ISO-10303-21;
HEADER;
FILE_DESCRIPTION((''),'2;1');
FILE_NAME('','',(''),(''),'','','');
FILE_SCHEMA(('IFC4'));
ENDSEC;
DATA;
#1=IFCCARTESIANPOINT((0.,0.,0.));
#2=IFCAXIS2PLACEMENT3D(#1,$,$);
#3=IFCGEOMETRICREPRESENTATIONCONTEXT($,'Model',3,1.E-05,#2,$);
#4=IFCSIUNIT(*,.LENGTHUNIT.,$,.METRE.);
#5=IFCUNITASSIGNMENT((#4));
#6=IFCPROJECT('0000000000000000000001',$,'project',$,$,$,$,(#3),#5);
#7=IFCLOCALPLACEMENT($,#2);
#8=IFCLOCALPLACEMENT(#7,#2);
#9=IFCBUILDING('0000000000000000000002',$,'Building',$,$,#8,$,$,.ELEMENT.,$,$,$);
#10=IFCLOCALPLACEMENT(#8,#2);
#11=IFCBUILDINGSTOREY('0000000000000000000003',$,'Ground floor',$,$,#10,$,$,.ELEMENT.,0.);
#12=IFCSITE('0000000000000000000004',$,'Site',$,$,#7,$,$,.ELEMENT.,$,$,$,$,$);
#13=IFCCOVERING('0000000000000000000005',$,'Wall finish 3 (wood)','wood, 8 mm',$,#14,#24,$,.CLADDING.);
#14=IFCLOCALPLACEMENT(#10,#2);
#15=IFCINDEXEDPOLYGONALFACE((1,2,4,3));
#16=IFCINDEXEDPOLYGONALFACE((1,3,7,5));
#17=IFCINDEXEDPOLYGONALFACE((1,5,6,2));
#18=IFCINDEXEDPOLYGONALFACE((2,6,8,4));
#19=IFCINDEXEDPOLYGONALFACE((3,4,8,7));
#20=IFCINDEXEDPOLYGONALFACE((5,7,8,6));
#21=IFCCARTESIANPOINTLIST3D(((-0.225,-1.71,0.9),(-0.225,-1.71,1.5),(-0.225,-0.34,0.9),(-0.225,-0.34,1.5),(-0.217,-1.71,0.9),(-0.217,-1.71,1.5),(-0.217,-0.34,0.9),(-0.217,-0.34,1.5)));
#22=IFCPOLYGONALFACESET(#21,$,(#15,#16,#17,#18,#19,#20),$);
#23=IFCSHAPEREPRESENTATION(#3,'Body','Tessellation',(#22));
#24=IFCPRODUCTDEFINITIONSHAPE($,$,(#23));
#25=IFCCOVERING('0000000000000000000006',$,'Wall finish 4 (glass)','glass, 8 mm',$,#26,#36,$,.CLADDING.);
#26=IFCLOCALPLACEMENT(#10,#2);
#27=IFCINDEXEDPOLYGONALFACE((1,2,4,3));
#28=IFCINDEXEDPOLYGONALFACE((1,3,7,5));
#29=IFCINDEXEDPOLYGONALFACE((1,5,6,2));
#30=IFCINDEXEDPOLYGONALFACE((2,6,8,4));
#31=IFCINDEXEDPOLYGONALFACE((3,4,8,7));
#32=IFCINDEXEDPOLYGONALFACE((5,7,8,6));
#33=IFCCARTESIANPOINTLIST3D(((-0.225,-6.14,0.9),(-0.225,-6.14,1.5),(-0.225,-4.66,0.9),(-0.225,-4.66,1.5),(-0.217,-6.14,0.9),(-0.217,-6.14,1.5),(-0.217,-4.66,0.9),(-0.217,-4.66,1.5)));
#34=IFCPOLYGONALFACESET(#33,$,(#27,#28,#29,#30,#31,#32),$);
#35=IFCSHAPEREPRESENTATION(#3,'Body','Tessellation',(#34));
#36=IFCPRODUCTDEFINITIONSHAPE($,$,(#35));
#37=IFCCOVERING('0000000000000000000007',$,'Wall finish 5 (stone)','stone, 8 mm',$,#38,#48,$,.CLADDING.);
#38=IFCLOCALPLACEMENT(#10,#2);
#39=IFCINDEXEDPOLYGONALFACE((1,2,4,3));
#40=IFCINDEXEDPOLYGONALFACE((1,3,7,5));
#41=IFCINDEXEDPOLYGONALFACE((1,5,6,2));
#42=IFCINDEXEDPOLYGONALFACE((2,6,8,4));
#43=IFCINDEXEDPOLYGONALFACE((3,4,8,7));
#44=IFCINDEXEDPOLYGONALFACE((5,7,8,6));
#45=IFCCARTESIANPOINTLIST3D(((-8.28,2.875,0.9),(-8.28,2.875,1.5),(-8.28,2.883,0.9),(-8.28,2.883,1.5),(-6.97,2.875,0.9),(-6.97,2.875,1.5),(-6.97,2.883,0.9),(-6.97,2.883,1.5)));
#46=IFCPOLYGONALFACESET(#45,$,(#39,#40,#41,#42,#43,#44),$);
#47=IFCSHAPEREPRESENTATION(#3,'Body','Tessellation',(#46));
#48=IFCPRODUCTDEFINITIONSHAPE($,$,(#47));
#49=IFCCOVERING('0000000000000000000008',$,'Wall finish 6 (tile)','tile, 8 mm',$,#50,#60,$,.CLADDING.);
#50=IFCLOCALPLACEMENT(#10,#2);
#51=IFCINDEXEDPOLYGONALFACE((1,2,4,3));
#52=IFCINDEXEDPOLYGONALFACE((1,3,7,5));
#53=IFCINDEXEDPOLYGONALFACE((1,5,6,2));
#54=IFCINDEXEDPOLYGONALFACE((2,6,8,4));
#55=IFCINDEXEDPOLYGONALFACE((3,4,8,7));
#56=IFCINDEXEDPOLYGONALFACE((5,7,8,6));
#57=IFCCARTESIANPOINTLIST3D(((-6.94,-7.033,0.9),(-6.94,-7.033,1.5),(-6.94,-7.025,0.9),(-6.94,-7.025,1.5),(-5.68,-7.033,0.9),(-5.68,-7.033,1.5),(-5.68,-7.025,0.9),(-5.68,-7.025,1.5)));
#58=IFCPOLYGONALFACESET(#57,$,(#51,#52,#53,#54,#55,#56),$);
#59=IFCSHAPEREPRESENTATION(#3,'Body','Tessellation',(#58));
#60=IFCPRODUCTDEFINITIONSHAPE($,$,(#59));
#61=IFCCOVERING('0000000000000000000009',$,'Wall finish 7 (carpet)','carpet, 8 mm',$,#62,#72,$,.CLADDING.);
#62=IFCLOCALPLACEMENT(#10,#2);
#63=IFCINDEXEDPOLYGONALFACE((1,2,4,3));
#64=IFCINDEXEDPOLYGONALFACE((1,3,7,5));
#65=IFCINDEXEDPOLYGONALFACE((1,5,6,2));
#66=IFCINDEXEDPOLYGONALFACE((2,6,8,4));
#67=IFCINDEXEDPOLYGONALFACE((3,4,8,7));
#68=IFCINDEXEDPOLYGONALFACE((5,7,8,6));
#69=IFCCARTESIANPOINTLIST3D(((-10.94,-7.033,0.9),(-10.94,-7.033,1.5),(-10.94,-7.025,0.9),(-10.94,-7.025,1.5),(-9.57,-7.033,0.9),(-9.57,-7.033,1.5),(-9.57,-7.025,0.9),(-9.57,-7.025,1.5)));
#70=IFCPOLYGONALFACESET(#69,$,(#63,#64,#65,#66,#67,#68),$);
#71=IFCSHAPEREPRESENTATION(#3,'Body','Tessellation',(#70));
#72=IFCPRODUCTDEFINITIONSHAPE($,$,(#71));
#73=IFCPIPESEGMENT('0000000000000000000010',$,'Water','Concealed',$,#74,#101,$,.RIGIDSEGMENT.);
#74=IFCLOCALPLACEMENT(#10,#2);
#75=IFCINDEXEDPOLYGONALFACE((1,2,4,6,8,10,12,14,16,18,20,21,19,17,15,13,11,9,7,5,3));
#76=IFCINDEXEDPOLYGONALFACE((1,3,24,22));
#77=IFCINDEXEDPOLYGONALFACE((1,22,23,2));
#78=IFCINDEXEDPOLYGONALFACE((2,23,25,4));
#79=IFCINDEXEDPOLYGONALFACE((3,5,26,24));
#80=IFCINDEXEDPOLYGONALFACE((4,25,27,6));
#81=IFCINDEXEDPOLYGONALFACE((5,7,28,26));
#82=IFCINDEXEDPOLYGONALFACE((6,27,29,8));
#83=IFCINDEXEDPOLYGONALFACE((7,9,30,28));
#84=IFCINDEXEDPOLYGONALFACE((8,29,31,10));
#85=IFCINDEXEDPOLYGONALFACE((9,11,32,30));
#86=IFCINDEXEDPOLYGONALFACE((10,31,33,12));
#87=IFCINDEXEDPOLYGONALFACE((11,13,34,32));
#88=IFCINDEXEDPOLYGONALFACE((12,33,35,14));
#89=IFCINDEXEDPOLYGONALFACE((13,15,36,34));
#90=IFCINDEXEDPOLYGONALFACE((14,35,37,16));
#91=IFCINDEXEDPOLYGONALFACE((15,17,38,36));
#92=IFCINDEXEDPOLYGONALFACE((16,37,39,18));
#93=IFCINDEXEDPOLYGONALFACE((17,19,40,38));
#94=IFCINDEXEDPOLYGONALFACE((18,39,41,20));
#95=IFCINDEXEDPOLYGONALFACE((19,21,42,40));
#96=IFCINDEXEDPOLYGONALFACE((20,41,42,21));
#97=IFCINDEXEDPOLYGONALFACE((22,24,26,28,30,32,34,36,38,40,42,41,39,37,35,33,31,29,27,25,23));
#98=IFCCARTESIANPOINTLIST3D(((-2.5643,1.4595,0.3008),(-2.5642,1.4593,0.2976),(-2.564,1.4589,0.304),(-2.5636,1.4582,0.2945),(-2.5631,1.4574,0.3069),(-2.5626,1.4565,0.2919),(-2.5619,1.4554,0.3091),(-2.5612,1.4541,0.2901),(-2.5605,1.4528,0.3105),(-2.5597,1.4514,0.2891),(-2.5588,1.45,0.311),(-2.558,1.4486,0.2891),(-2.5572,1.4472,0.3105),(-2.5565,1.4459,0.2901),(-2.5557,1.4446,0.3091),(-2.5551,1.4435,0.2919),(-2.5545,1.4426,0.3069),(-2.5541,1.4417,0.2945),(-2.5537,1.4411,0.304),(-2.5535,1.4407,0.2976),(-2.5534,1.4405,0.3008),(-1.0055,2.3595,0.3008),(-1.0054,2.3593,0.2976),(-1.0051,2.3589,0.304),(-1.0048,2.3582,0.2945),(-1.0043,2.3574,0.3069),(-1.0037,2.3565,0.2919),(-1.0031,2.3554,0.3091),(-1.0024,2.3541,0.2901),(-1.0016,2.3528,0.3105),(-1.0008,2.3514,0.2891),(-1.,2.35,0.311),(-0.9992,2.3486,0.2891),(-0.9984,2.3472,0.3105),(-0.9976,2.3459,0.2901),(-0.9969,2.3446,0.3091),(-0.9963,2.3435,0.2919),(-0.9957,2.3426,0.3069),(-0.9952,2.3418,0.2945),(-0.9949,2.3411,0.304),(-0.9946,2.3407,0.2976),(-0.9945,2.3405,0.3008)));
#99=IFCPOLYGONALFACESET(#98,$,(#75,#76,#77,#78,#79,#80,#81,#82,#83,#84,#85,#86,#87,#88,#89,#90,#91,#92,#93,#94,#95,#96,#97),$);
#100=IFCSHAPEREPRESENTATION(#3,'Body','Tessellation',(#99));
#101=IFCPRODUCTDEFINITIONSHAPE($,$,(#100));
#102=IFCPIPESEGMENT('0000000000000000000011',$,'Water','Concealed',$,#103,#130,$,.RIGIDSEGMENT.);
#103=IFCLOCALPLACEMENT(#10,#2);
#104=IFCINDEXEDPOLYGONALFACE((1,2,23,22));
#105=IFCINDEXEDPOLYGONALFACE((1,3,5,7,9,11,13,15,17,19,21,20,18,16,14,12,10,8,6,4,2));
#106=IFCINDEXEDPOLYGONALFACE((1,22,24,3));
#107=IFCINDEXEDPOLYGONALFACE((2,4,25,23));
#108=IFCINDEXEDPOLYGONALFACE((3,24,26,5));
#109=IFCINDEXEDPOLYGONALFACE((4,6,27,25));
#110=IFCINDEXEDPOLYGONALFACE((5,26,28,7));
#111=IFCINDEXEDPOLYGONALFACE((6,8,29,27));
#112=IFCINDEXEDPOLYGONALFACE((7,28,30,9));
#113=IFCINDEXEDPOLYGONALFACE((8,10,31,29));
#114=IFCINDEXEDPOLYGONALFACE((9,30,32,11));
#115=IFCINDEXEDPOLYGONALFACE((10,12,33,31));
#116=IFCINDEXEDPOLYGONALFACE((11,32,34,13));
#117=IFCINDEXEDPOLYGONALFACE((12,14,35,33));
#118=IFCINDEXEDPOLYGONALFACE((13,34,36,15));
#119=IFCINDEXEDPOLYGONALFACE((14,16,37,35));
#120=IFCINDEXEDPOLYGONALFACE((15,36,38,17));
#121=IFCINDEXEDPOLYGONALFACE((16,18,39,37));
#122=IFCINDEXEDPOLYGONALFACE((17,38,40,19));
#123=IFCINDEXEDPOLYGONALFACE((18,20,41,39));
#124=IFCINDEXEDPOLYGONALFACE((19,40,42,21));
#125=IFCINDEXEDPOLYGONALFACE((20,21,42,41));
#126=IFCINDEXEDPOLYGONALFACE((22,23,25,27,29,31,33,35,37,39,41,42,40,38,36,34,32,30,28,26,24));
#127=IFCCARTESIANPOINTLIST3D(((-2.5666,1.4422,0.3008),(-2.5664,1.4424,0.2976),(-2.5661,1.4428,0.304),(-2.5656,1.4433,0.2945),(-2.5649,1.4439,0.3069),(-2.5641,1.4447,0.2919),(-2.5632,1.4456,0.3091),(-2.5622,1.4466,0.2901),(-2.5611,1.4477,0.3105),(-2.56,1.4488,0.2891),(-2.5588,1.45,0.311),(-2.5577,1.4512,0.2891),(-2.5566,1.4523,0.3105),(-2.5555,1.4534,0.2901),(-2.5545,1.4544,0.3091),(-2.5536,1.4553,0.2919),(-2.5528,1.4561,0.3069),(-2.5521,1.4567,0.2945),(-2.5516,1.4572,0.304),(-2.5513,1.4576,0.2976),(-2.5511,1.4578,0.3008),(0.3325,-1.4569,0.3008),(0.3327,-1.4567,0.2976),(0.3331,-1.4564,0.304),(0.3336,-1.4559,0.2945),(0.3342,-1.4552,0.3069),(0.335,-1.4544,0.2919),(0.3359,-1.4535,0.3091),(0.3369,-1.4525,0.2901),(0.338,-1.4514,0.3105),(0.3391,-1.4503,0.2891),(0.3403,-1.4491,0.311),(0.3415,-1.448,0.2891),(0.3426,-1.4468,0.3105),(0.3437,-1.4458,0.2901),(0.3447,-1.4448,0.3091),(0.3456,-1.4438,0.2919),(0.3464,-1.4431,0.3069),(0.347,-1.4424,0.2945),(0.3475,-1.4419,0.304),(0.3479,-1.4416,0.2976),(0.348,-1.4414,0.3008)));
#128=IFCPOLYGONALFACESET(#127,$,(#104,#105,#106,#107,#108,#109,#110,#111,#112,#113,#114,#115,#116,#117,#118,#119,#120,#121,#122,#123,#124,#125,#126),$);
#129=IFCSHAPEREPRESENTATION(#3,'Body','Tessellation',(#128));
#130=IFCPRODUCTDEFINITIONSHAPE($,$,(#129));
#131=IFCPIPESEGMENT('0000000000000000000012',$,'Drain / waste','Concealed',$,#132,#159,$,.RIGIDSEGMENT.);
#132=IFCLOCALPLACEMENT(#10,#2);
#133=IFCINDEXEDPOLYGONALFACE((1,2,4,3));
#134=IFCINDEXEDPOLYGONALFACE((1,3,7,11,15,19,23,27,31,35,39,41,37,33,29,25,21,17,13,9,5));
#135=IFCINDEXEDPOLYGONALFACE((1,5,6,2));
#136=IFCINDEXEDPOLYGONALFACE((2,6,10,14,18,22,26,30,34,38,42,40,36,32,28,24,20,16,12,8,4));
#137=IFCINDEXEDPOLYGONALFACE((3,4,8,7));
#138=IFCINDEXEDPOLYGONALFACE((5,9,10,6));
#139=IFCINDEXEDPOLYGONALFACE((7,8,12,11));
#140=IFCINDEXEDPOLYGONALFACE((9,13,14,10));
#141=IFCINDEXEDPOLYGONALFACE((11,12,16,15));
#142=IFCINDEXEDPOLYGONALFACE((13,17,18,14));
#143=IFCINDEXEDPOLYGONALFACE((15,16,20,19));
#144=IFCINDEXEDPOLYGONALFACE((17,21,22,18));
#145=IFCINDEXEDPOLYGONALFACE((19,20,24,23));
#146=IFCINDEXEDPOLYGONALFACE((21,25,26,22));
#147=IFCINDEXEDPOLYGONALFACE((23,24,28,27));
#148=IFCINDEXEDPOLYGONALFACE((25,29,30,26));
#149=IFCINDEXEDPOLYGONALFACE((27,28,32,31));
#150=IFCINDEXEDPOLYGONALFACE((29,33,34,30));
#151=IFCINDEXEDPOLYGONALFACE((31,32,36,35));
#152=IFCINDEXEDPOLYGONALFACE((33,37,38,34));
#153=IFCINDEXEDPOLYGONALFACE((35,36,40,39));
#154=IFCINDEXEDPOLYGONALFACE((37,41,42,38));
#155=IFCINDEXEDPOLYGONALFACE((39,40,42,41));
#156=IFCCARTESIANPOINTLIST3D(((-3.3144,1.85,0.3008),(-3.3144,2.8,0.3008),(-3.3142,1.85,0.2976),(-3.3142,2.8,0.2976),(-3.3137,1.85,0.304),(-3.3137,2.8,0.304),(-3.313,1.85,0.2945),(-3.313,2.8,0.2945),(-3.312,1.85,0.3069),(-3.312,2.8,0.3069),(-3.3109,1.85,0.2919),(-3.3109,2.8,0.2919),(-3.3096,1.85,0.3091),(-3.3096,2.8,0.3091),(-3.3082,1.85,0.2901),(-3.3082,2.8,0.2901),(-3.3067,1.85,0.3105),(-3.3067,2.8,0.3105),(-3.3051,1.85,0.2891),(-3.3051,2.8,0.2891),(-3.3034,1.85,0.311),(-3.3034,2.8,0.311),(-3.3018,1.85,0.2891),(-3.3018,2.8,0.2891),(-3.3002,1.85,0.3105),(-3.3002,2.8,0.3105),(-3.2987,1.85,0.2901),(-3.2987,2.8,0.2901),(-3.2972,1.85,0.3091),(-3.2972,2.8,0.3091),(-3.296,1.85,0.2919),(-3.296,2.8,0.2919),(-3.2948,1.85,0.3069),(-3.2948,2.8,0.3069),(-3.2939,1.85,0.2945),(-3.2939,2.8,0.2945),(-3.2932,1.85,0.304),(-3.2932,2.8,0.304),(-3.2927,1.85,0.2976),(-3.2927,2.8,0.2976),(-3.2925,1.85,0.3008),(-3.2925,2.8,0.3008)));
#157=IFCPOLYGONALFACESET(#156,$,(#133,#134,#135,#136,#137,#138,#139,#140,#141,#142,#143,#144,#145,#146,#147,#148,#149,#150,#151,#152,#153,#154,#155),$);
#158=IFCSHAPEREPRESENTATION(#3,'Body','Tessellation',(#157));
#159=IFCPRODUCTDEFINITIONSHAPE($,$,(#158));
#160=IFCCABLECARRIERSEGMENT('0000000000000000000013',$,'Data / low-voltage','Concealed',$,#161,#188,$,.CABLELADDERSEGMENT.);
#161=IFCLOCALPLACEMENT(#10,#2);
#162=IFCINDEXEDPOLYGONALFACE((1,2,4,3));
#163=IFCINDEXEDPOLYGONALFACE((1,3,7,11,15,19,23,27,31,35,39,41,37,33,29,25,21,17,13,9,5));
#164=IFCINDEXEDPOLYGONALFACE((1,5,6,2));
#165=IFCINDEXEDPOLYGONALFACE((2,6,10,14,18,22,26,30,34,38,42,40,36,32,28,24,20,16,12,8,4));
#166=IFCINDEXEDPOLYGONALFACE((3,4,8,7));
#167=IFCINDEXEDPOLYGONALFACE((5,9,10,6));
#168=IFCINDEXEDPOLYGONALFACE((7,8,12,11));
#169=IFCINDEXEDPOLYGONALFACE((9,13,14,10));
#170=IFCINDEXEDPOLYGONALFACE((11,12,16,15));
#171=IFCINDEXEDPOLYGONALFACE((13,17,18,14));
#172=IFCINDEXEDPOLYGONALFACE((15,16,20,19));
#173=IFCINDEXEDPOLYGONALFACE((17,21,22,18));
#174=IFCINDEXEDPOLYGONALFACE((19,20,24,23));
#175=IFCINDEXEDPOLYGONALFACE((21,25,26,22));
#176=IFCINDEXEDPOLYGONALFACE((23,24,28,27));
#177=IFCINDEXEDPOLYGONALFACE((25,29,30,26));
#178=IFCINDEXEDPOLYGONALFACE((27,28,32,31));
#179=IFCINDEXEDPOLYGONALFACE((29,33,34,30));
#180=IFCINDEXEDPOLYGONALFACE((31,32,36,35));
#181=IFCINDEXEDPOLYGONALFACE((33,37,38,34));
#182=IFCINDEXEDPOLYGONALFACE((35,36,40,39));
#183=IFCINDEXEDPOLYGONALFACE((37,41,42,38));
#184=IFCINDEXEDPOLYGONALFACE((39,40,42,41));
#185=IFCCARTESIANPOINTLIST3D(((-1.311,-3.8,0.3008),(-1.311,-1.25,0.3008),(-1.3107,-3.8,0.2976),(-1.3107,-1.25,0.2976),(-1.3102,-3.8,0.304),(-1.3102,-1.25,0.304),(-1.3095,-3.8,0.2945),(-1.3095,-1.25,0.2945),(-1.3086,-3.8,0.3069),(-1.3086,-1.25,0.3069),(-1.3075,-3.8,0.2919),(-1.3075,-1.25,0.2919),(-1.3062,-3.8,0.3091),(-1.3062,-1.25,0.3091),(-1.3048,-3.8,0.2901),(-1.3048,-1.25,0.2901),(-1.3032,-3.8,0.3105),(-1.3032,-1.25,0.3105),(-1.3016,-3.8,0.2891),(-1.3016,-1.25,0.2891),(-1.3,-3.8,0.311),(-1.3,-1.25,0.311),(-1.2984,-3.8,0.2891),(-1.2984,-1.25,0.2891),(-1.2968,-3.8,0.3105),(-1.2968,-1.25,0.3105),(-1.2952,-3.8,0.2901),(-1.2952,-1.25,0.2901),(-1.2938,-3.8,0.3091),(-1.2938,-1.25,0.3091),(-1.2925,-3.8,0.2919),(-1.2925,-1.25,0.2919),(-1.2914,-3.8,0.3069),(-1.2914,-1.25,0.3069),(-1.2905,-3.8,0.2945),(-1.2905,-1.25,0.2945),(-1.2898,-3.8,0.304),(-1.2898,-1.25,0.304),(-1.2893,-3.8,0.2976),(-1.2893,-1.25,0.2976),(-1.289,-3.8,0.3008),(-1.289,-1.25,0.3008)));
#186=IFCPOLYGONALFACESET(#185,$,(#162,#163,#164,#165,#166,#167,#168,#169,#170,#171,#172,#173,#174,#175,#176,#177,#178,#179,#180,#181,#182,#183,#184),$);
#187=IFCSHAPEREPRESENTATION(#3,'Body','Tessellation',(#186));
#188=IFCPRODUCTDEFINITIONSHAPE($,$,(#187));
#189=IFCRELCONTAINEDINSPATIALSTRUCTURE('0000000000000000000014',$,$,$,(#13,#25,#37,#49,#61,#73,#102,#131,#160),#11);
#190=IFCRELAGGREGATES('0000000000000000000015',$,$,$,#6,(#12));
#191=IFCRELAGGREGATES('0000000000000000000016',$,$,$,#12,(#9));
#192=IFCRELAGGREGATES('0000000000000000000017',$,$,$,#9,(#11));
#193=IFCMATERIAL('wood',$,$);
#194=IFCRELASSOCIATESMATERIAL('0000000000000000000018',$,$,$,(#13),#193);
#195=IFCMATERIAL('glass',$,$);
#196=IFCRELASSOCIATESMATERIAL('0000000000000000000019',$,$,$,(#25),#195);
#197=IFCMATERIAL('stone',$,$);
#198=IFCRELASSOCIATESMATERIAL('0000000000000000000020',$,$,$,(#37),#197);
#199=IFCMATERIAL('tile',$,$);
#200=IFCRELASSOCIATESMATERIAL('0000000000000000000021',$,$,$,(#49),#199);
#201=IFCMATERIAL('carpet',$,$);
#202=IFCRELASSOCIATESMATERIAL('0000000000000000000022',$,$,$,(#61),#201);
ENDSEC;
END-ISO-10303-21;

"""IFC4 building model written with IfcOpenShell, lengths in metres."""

from ifc_helpers import new_model, si_unit, frame, origin, origin_with_axes, origin_2d, place, context, project, spatial, polyline, circle, outline, extrude, material, element, save


model = new_model("IFC4")

# Units and contexts
model_context = context("Model", 3, precision=1e-05, world=origin())
ifc_project = project(units=[si_unit("LENGTHUNIT", "METRE")], contexts=[model_context])

# Site, building, storey
site_placement = place(None, origin())
site = spatial("IfcSite", under=ifc_project, at=site_placement, Name="Site", CompositionType="ELEMENT")
building_placement = place(site_placement, origin())
building = spatial("IfcBuilding", under=site, at=building_placement, Name="Building", CompositionType="ELEMENT")
storey_placement = place(building_placement, origin())
storey = spatial("IfcBuildingStorey", under=building, at=storey_placement, Name="Ground floor", CompositionType="ELEMENT", Elevation=0.0)

# Coverings
ifc_material_1 = material(Name="tile")
ifc_material_2 = material(Name="wood")
covering_1_placement = place(storey_placement, origin_with_axes())
element("IfcCovering", 1, at=covering_1_placement, inside=storey, material=ifc_material_2, Name="Wall finish 3 (wood)", Description="wood, 8 mm", PredefinedType="CLADDING", context=model_context, shape_type="SweptSolid", body=[
    extrude(outline(polyline([(-0.225, -0.34), (-0.225, -1.71), (-0.217, -1.71), (-0.217, -0.34), (-0.225, -0.34)])), frame((0.0, 0.0, 0.9)), (0.0, 0.0, 1.0), 0.6),
])
ifc_material_3 = material(Name="glass")
covering_2_placement = place(storey_placement, origin_with_axes())
element("IfcCovering", 2, at=covering_2_placement, inside=storey, material=ifc_material_3, Name="Wall finish 4 (glass)", Description="glass, 8 mm", PredefinedType="CLADDING", context=model_context, shape_type="SweptSolid", body=[
    extrude(outline(polyline([(-0.225, -4.66), (-0.225, -6.14), (-0.217, -6.14), (-0.217, -4.66), (-0.225, -4.66)])), frame((0.0, 0.0, 0.9)), (0.0, 0.0, 1.0), 0.6),
])
ifc_material_4 = material(Name="stone")
covering_3_placement = place(storey_placement, origin_with_axes())
element("IfcCovering", 3, at=covering_3_placement, inside=storey, material=ifc_material_4, Name="Wall finish 5 (stone)", Description="stone, 8 mm", PredefinedType="CLADDING", context=model_context, shape_type="SweptSolid", body=[
    extrude(outline(polyline([(-8.28, 2.875), (-6.97, 2.875), (-6.97, 2.883), (-8.28, 2.883), (-8.28, 2.875)])), frame((0.0, 0.0, 0.9)), (0.0, 0.0, 1.0), 0.6),
])
covering_4_placement = place(storey_placement, origin_with_axes())
element("IfcCovering", 4, at=covering_4_placement, inside=storey, material=ifc_material_1, Name="Wall finish 6 (tile)", Description="tile, 8 mm", PredefinedType="CLADDING", context=model_context, shape_type="SweptSolid", body=[
    extrude(outline(polyline([(-5.68, -7.025), (-6.94, -7.025), (-6.94, -7.033), (-5.68, -7.033), (-5.68, -7.025)])), frame((0.0, 0.0, 0.9)), (0.0, 0.0, 1.0), 0.6),
])
ifc_material_5 = material(Name="carpet")
covering_5_placement = place(storey_placement, origin_with_axes())
element("IfcCovering", 5, at=covering_5_placement, inside=storey, material=ifc_material_5, Name="Wall finish 7 (carpet)", Description="carpet, 8 mm", PredefinedType="CLADDING", context=model_context, shape_type="SweptSolid", body=[
    extrude(outline(polyline([(-9.57, -7.025), (-10.94, -7.025), (-10.94, -7.033), (-9.57, -7.033), (-9.57, -7.025)])), frame((0.0, 0.0, 0.9)), (0.0, 0.0, 1.0), 0.6),
])

# Pipe segments
pipe_segment_1_placement = place(storey_placement, frame((-1.0, 2.35, 0.3), z_axis=(-0.866025, -0.5, 0.0), x_axis=(0.0, 0.0, 1.0)))
element("IfcPipeSegment", 6, at=pipe_segment_1_placement, inside=storey, Name="Water", Description="Concealed", PredefinedType="RIGIDSEGMENT", context=model_context, shape_type="SweptSolid", body=[
    extrude(circle(Radius=0.011, at=origin_2d()), origin(), (0.0, 0.0, 1.0), 1.8),
])
pipe_segment_2_placement = place(storey_placement, frame((-2.5588, 1.45, 0.3), z_axis=(0.707107, -0.707107, 0.0), x_axis=(0.0, 0.0, 1.0)))
element("IfcPipeSegment", 7, at=pipe_segment_2_placement, inside=storey, Name="Water", Description="Concealed", PredefinedType="RIGIDSEGMENT", context=model_context, shape_type="SweptSolid", body=[
    extrude(circle(Radius=0.011, at=origin_2d()), origin(), (0.0, 0.0, 1.0), 4.1),
])
pipe_segment_3_placement = place(storey_placement, frame((-3.3034, 2.8, 0.3), z_axis=(0.0, -1.0, 0.0), x_axis=(0.0, 0.0, 1.0)))
element("IfcPipeSegment", 8, at=pipe_segment_3_placement, inside=storey, Name="Drain / waste", Description="Concealed", PredefinedType="RIGIDSEGMENT", context=model_context, shape_type="SweptSolid", body=[
    extrude(circle(Radius=0.011, at=origin_2d()), origin(), (0.0, 0.0, 1.0), 0.95),
])

# Cable carrier segment
cable_carrier_segment_placement = place(storey_placement, frame((-1.3, -1.25, 0.3), z_axis=(0.0, -1.0, 0.0), x_axis=(0.0, 0.0, 1.0)))
element("IfcCableCarrierSegment", 9, at=cable_carrier_segment_placement, inside=storey, Name="Data / low-voltage", Description="Concealed", PredefinedType="CABLELADDERSEGMENT", context=model_context, shape_type="SweptSolid", body=[
    extrude(circle(Radius=0.011, at=origin_2d()), origin(), (0.0, 0.0, 1.0), 2.55),
])

save(model, "model.ifc")
